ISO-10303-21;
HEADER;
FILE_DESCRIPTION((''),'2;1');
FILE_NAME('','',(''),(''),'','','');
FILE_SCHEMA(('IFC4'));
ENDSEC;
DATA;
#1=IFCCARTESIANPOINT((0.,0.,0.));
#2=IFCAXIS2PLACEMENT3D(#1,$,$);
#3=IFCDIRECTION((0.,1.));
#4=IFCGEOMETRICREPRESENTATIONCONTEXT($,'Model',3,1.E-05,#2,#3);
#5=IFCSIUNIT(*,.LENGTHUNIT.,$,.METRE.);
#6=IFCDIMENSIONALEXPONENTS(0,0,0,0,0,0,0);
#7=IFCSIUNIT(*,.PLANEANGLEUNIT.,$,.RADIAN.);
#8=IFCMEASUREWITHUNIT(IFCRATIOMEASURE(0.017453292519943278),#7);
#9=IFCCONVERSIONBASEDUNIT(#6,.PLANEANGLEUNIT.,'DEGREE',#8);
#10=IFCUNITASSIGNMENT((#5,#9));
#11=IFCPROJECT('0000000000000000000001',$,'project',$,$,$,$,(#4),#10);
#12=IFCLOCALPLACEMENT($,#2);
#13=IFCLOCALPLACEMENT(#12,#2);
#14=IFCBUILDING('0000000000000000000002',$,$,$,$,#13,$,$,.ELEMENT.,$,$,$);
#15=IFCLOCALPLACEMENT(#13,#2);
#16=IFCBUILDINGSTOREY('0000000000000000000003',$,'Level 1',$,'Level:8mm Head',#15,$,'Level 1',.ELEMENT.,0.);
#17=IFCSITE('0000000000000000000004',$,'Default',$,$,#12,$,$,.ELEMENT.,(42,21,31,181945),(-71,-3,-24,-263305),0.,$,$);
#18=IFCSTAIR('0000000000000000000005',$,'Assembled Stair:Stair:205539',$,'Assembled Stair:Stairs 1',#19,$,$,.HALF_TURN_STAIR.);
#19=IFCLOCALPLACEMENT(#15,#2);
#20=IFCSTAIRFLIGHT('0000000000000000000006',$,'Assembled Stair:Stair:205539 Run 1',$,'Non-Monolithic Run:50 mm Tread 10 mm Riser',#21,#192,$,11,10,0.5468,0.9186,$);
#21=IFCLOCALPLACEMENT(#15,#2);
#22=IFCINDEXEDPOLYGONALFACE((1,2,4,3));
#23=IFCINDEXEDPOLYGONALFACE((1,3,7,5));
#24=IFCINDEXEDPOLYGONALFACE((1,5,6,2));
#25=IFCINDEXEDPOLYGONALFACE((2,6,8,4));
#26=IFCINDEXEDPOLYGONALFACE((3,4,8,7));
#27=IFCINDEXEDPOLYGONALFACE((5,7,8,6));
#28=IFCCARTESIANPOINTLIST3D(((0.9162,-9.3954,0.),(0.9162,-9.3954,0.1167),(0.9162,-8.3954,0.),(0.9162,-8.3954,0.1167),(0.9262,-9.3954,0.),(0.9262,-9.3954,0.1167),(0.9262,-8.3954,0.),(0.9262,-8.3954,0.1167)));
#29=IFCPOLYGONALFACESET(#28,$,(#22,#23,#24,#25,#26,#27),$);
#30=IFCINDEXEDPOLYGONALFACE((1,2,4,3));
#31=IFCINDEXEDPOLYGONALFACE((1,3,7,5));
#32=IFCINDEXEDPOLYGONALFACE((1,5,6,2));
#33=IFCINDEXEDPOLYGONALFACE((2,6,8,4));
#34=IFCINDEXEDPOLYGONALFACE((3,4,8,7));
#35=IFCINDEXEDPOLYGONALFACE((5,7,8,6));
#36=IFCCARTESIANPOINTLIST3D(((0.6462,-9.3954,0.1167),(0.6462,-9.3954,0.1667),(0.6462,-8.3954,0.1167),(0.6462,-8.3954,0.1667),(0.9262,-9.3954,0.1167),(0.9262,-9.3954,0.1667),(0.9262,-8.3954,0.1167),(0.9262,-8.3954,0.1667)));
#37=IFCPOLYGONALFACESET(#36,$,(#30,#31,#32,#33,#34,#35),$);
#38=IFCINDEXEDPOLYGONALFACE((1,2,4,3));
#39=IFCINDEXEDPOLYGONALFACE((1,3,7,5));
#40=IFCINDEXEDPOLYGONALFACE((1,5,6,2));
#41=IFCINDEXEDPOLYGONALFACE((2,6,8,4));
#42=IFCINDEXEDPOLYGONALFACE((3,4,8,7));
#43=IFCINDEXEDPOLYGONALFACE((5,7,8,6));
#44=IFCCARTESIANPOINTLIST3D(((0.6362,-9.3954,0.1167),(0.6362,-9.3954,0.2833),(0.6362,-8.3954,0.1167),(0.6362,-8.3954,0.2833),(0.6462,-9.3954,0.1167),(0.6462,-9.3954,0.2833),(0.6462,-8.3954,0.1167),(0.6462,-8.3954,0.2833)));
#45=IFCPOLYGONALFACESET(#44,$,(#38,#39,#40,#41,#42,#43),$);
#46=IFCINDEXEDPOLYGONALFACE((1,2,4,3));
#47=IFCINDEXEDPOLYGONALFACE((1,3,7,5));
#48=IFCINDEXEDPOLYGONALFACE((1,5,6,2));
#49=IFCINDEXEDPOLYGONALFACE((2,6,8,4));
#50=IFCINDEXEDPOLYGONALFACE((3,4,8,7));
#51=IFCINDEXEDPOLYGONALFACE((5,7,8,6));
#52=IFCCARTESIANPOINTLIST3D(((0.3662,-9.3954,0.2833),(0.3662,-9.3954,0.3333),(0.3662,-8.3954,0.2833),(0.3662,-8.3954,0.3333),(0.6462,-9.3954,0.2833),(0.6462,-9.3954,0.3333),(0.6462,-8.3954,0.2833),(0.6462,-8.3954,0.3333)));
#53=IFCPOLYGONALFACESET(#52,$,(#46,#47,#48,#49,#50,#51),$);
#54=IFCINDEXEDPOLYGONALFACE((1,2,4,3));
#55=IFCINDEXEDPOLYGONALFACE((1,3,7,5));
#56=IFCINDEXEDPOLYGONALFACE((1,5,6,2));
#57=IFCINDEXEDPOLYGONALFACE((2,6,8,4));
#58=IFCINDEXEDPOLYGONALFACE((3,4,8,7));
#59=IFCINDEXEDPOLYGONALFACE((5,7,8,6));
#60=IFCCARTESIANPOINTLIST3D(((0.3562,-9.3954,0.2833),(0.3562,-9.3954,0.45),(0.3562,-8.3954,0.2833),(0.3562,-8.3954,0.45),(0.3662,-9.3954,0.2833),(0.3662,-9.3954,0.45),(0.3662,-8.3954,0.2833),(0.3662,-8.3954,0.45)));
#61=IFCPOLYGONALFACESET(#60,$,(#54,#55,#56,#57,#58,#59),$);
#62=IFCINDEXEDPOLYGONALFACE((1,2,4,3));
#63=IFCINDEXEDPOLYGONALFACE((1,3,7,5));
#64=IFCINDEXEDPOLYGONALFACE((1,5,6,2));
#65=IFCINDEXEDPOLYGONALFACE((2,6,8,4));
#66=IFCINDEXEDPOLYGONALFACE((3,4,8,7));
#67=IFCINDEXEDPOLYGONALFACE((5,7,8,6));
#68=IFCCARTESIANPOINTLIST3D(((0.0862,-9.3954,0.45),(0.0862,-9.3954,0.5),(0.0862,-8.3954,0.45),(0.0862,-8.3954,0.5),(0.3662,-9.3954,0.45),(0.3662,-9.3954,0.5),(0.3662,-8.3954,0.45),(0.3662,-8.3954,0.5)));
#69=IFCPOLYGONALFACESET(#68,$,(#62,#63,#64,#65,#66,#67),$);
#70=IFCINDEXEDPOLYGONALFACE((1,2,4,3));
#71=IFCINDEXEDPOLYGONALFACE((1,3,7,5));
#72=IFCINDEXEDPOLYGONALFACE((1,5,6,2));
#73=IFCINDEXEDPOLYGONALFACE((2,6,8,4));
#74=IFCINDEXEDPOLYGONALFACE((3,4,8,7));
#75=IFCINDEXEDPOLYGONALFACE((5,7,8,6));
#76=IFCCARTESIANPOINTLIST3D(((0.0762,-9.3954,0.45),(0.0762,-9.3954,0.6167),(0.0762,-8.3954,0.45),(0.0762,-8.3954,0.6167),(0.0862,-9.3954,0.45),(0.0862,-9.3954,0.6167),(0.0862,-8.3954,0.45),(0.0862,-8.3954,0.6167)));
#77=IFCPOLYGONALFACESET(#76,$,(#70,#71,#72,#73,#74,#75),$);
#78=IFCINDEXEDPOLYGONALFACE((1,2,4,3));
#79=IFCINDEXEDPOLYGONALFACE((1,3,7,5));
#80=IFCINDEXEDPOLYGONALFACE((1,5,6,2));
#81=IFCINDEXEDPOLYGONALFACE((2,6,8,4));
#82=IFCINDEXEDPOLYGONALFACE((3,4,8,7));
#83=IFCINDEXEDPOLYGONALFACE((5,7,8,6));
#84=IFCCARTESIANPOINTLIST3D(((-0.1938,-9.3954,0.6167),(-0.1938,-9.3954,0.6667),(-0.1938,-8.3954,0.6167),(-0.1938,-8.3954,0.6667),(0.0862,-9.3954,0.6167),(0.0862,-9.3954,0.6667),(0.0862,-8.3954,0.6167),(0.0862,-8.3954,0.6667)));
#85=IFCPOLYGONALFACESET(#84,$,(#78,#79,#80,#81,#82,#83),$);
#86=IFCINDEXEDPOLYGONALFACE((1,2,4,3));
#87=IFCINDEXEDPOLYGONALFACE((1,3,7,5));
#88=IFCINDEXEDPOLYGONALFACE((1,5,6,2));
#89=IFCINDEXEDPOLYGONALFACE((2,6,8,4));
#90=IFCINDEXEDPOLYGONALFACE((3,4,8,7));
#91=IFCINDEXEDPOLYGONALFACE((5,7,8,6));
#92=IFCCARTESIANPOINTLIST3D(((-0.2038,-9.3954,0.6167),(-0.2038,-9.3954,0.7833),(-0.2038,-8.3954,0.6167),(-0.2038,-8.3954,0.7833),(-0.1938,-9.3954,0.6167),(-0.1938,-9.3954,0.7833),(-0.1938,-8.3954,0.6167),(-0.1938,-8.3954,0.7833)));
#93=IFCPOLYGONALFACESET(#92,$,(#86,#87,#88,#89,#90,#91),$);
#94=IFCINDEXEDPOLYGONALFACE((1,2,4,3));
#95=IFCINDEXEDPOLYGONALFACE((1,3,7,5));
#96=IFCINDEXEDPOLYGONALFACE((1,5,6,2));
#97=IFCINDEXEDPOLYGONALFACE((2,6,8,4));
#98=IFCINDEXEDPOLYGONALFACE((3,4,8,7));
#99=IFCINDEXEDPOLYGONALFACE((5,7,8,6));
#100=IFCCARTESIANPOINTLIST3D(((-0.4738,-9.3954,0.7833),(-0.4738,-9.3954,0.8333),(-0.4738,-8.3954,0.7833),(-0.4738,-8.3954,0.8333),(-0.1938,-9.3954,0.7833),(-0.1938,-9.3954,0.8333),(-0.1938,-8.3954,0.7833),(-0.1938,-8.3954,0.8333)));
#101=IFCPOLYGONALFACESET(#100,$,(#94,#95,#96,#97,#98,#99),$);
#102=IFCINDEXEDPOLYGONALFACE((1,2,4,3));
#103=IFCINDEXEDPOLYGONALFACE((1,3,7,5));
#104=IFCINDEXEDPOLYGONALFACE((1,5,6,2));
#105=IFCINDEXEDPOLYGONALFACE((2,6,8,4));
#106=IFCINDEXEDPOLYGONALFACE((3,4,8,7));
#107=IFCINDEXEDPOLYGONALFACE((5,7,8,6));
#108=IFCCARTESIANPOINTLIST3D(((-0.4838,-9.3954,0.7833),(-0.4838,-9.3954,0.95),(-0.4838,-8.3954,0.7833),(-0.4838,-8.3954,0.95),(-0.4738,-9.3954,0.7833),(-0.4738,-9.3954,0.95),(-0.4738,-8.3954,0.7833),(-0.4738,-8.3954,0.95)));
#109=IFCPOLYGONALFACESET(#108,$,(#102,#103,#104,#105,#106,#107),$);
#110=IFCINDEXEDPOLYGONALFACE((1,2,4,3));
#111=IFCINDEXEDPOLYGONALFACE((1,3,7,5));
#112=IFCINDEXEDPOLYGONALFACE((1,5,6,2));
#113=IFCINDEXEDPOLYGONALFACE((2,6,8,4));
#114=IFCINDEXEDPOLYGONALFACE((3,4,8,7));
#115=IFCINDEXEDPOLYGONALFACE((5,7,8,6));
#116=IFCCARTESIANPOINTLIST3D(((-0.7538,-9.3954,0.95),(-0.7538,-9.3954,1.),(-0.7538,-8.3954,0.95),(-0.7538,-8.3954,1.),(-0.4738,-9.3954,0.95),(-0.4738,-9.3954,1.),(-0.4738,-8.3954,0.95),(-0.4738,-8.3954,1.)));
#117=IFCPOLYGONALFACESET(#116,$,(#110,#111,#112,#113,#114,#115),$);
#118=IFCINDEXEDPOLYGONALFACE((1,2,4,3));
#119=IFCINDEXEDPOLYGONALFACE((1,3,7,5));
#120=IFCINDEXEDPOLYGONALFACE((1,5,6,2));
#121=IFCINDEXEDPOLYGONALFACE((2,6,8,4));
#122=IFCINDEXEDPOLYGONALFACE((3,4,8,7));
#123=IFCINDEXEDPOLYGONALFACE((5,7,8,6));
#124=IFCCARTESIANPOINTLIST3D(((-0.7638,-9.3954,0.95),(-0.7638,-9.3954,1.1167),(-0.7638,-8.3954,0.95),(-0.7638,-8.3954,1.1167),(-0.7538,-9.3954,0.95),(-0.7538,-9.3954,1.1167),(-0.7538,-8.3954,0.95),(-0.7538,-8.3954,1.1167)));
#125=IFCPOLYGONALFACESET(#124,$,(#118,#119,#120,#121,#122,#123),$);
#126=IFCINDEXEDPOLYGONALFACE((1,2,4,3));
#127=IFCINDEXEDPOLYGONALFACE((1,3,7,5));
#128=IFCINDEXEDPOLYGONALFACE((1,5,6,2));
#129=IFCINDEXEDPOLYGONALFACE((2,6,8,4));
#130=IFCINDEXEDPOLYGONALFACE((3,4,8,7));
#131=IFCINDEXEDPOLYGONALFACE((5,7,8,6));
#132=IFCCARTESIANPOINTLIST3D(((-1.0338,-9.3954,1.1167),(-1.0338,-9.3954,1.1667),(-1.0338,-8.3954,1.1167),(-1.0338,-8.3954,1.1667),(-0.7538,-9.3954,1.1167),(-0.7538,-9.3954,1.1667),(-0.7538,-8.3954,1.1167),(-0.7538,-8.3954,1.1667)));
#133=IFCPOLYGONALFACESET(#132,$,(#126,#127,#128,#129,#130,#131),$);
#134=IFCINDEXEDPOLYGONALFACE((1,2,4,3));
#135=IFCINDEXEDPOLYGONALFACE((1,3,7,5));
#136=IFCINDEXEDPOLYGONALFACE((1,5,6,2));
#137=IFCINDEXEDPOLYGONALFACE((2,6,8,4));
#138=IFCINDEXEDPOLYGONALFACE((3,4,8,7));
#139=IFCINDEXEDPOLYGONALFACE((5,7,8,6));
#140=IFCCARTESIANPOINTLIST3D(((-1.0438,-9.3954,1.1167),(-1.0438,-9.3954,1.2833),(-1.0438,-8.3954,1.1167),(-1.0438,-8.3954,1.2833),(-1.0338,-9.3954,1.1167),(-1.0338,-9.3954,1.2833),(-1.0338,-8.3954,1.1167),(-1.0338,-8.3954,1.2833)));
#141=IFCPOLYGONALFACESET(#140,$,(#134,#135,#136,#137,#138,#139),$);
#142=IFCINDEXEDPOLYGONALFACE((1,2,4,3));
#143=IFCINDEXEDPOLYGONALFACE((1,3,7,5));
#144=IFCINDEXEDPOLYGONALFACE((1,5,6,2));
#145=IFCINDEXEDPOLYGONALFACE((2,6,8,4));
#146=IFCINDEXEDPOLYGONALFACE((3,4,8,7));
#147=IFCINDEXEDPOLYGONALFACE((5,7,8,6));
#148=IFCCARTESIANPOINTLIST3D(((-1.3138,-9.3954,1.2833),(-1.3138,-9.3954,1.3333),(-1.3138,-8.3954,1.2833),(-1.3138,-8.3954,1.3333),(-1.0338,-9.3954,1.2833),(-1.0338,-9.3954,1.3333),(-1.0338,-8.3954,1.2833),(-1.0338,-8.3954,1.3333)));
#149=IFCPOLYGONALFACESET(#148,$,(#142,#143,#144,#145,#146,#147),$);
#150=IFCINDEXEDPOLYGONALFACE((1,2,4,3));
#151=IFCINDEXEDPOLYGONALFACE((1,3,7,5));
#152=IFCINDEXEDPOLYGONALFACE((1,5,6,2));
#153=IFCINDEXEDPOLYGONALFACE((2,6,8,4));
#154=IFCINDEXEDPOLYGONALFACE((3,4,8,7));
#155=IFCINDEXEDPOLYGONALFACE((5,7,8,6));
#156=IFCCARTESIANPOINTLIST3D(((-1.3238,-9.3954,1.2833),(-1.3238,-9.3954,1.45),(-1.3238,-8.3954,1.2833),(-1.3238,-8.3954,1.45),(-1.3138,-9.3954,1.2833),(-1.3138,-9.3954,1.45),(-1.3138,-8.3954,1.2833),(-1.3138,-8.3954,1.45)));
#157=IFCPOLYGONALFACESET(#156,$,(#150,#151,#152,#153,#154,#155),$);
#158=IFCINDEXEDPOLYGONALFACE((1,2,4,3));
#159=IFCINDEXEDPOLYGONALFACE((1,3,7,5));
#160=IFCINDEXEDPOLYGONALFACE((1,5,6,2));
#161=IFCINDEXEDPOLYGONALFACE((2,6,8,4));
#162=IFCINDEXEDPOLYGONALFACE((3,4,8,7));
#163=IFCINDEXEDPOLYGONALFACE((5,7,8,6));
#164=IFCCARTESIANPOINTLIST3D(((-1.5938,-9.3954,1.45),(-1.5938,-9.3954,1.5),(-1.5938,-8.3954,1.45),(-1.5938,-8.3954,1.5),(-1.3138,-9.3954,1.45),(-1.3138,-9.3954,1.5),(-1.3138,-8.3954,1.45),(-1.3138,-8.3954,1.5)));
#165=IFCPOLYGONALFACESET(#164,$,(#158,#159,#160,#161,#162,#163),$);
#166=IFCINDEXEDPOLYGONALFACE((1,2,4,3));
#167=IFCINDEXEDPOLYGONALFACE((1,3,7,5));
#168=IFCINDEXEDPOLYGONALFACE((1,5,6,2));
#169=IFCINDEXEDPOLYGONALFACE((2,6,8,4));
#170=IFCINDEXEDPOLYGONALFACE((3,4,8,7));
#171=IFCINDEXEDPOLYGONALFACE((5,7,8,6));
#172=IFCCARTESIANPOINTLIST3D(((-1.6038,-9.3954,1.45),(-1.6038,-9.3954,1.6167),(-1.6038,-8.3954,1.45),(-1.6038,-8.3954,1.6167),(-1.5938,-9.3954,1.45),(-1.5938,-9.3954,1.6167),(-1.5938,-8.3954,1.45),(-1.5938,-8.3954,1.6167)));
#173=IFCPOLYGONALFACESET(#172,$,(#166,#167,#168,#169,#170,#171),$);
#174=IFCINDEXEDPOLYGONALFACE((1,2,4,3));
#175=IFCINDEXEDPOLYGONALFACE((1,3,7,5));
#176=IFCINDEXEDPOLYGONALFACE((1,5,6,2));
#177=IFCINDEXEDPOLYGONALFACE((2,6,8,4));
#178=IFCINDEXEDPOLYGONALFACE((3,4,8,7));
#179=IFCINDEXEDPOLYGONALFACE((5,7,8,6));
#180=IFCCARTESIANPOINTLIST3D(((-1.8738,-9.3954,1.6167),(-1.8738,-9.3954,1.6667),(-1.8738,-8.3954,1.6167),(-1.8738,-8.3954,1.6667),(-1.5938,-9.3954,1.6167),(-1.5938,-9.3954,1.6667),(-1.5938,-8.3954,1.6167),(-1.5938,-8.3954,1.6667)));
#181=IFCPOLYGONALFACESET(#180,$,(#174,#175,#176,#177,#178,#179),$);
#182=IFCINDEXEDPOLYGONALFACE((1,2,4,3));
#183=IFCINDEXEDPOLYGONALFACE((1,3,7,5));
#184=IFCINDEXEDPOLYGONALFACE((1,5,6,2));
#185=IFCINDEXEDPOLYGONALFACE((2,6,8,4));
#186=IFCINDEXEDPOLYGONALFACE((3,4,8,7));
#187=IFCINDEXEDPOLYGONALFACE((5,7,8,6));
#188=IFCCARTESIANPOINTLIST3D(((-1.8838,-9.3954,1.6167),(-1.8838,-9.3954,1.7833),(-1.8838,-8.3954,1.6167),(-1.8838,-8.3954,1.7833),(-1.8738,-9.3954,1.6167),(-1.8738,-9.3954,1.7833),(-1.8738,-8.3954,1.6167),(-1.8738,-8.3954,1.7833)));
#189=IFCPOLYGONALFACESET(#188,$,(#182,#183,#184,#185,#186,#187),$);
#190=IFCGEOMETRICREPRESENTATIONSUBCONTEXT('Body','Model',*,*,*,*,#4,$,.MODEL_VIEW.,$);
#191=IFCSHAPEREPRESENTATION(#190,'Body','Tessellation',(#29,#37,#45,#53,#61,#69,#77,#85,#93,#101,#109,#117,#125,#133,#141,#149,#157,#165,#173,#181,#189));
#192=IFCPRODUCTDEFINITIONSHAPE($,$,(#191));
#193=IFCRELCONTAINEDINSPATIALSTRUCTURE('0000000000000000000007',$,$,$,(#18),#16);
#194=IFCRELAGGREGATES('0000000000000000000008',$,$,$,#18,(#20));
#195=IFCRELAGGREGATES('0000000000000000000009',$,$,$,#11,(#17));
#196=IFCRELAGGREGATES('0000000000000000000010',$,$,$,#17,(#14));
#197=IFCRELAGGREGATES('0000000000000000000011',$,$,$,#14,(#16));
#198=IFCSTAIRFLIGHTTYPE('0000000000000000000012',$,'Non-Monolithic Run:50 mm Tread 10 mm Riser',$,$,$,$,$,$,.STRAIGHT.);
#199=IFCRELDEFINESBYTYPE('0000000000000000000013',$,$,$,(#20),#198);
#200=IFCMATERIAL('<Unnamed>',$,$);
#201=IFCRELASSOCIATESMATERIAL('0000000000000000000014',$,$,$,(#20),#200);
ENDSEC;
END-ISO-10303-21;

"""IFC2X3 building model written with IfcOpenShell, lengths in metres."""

from ifc_helpers import new_model, entity, si_unit, converted_unit, direction, frame, frame_2d, origin, origin_2d_with_axis, place, context, subcontext, project, spatial, rectangle, extrude, material, type_object, element, aggregate, save


model = new_model("IFC2X3")

# Units and contexts
model_context = context("Model", 3, precision=1e-05, world=origin(), true_north=direction((0.0, 1.0)))
body_context = subcontext(model_context, "Body", "Model", "MODEL_VIEW")
ifc_project = project(units=[si_unit("LENGTHUNIT", "METRE"), converted_unit("PLANEANGLEUNIT", "DEGREE", entity("IfcRatioMeasure", 0.017453292519943278), si_unit("PLANEANGLEUNIT", "RADIAN"), dimensions=[0, 0, 0, 0, 0, 0, 0])], contexts=[model_context])

# Site, building, storey
site_placement = place(None, origin())
site = spatial("IfcSite", under=ifc_project, at=site_placement, Name="Default", CompositionType="ELEMENT", RefLatitude=(42, 21, 31, 181945), RefLongitude=(-71, -3, -24, -263305), RefElevation=0.0)
building_placement = place(site_placement, origin())
building = spatial("IfcBuilding", under=site, at=building_placement, CompositionType="ELEMENT")
storey_placement = place(building_placement, origin())
storey = spatial("IfcBuildingStorey", under=building, at=storey_placement, Name="Level 1", ObjectType="Level:8mm Head", LongName="Level 1", CompositionType="ELEMENT", Elevation=0.0)

# Stair
stair_placement = place(storey_placement, origin())
stair = element("IfcStair", 1, at=stair_placement, inside=storey, Name="Assembled Stair:Stair:205539", ObjectType="Assembled Stair:Stairs 1", ShapeType="HALF_TURN_STAIR")
ifc_material_1 = material(Name="<Unnamed>")

# Stair flight
stair_flight_type_1 = type_object("IfcStairFlightType", Name="Non-Monolithic Run:50 mm Tread 10 mm Riser", PredefinedType="STRAIGHT")
stair_flight_1_placement = place(stair_placement, origin())
stair_flight_1 = element("IfcStairFlight", 2, at=stair_flight_1_placement, type_object=stair_flight_type_1, material=ifc_material_1, Name="Assembled Stair:Stair:205539 Run 1", ObjectType="Non-Monolithic Run:50 mm Tread 10 mm Riser", NumberOfRiser=11, NumberOfTreads=10, RiserHeight=0.5468, TreadLength=0.9186, context=body_context, shape_type="SweptSolid", body=[
    extrude(rectangle(XDim=1.0, YDim=0.01, at=frame_2d((0.0, 0.0), x_axis=(1.0, 0.0))), frame((0.9212, -8.8954, 0.0), z_axis=(0.0, 0.0, 1.0), x_axis=(0.0, -1.0, 0.0)), (0.0, 0.0, 1.0), 0.1167),
    extrude(rectangle(XDim=0.28, YDim=1.0, at=frame_2d((0.0, 0.0), x_axis=(1.0, 0.0))), frame((0.7862, -8.8954, 0.1167)), (0.0, 0.0, 1.0), 0.05),
    extrude(rectangle(XDim=1.0, YDim=0.01, at=frame_2d((0.0, 0.0), x_axis=(1.0, 0.0))), frame((0.6412, -8.8954, 0.1167), z_axis=(0.0, 0.0, 1.0), x_axis=(0.0, -1.0, 0.0)), (0.0, 0.0, 1.0), 0.1667),
    extrude(rectangle(XDim=0.28, YDim=1.0, at=frame_2d((0.0, 0.0), x_axis=(1.0, 0.0))), frame((0.5062, -8.8954, 0.2833)), (0.0, 0.0, 1.0), 0.05),
    extrude(rectangle(XDim=1.0, YDim=0.01, at=origin_2d_with_axis()), frame((0.3612, -8.8954, 0.2833), z_axis=(0.0, 0.0, 1.0), x_axis=(0.0, -1.0, 0.0)), (0.0, 0.0, 1.0), 0.1667),
    extrude(rectangle(XDim=0.28, YDim=1.0, at=origin_2d_with_axis()), frame((0.2262, -8.8954, 0.45)), (0.0, 0.0, 1.0), 0.05),
    extrude(rectangle(XDim=1.0, YDim=0.01, at=origin_2d_with_axis()), frame((0.0812, -8.8954, 0.45), z_axis=(0.0, 0.0, 1.0), x_axis=(0.0, -1.0, 0.0)), (0.0, 0.0, 1.0), 0.1667),
    extrude(rectangle(XDim=0.28, YDim=1.0, at=origin_2d_with_axis()), frame((-0.0538, -8.8954, 0.6167)), (0.0, 0.0, 1.0), 0.05),
    extrude(rectangle(XDim=1.0, YDim=0.01, at=origin_2d_with_axis()), frame((-0.1988, -8.8954, 0.6167), z_axis=(0.0, 0.0, 1.0), x_axis=(0.0, -1.0, 0.0)), (0.0, 0.0, 1.0), 0.1667),
    extrude(rectangle(XDim=0.28, YDim=1.0, at=origin_2d_with_axis()), frame((-0.3338, -8.8954, 0.7833)), (0.0, 0.0, 1.0), 0.05),
    extrude(rectangle(XDim=1.0, YDim=0.01, at=frame_2d((0.0, 0.0), x_axis=(1.0, 0.0))), frame((-0.4788, -8.8954, 0.7833), z_axis=(0.0, 0.0, 1.0), x_axis=(0.0, -1.0, 0.0)), (0.0, 0.0, 1.0), 0.1667),
    extrude(rectangle(XDim=0.28, YDim=1.0, at=frame_2d((0.0, 0.0), x_axis=(1.0, 0.0))), frame((-0.6138, -8.8954, 0.95)), (0.0, 0.0, 1.0), 0.05),
    extrude(rectangle(XDim=1.0, YDim=0.01, at=frame_2d((0.0, 0.0), x_axis=(1.0, 0.0))), frame((-0.7588, -8.8954, 0.95), z_axis=(0.0, 0.0, 1.0), x_axis=(0.0, -1.0, 0.0)), (0.0, 0.0, 1.0), 0.1667),
    extrude(rectangle(XDim=0.28, YDim=1.0, at=origin_2d_with_axis()), frame((-0.8938, -8.8954, 1.1167)), (0.0, 0.0, 1.0), 0.05),
    extrude(rectangle(XDim=1.0, YDim=0.01, at=frame_2d((0.0, 0.0), x_axis=(1.0, 0.0))), frame((-1.0388, -8.8954, 1.1167), z_axis=(0.0, 0.0, 1.0), x_axis=(0.0, -1.0, 0.0)), (0.0, 0.0, 1.0), 0.1667),
    extrude(rectangle(XDim=0.28, YDim=1.0, at=origin_2d_with_axis()), frame((-1.1738, -8.8954, 1.2833)), (0.0, 0.0, 1.0), 0.05),
    extrude(rectangle(XDim=1.0, YDim=0.01, at=frame_2d((0.0, 0.0), x_axis=(1.0, 0.0))), frame((-1.3188, -8.8954, 1.2833), z_axis=(0.0, 0.0, 1.0), x_axis=(0.0, -1.0, 0.0)), (0.0, 0.0, 1.0), 0.1667),
    extrude(rectangle(XDim=0.28, YDim=1.0, at=frame_2d((0.0, 0.0), x_axis=(1.0, 0.0))), frame((-1.4538, -8.8954, 1.45)), (0.0, 0.0, 1.0), 0.05),
    extrude(rectangle(XDim=1.0, YDim=0.01, at=frame_2d((0.0, 0.0), x_axis=(1.0, 0.0))), frame((-1.5988, -8.8954, 1.45), z_axis=(0.0, 0.0, 1.0), x_axis=(0.0, -1.0, 0.0)), (0.0, 0.0, 1.0), 0.1667),
    extrude(rectangle(XDim=0.28, YDim=1.0, at=frame_2d((0.0, 0.0), x_axis=(1.0, 0.0))), frame((-1.7338, -8.8954, 1.6167)), (0.0, 0.0, 1.0), 0.05),
    extrude(rectangle(XDim=1.0, YDim=0.01, at=origin_2d_with_axis()), frame((-1.8788, -8.8954, 1.6167), z_axis=(0.0, 0.0, 1.0), x_axis=(0.0, -1.0, 0.0)), (0.0, 0.0, 1.0), 0.1667),
])
aggregate(stair, [stair_flight_1])

save(model, "model.ifc")
